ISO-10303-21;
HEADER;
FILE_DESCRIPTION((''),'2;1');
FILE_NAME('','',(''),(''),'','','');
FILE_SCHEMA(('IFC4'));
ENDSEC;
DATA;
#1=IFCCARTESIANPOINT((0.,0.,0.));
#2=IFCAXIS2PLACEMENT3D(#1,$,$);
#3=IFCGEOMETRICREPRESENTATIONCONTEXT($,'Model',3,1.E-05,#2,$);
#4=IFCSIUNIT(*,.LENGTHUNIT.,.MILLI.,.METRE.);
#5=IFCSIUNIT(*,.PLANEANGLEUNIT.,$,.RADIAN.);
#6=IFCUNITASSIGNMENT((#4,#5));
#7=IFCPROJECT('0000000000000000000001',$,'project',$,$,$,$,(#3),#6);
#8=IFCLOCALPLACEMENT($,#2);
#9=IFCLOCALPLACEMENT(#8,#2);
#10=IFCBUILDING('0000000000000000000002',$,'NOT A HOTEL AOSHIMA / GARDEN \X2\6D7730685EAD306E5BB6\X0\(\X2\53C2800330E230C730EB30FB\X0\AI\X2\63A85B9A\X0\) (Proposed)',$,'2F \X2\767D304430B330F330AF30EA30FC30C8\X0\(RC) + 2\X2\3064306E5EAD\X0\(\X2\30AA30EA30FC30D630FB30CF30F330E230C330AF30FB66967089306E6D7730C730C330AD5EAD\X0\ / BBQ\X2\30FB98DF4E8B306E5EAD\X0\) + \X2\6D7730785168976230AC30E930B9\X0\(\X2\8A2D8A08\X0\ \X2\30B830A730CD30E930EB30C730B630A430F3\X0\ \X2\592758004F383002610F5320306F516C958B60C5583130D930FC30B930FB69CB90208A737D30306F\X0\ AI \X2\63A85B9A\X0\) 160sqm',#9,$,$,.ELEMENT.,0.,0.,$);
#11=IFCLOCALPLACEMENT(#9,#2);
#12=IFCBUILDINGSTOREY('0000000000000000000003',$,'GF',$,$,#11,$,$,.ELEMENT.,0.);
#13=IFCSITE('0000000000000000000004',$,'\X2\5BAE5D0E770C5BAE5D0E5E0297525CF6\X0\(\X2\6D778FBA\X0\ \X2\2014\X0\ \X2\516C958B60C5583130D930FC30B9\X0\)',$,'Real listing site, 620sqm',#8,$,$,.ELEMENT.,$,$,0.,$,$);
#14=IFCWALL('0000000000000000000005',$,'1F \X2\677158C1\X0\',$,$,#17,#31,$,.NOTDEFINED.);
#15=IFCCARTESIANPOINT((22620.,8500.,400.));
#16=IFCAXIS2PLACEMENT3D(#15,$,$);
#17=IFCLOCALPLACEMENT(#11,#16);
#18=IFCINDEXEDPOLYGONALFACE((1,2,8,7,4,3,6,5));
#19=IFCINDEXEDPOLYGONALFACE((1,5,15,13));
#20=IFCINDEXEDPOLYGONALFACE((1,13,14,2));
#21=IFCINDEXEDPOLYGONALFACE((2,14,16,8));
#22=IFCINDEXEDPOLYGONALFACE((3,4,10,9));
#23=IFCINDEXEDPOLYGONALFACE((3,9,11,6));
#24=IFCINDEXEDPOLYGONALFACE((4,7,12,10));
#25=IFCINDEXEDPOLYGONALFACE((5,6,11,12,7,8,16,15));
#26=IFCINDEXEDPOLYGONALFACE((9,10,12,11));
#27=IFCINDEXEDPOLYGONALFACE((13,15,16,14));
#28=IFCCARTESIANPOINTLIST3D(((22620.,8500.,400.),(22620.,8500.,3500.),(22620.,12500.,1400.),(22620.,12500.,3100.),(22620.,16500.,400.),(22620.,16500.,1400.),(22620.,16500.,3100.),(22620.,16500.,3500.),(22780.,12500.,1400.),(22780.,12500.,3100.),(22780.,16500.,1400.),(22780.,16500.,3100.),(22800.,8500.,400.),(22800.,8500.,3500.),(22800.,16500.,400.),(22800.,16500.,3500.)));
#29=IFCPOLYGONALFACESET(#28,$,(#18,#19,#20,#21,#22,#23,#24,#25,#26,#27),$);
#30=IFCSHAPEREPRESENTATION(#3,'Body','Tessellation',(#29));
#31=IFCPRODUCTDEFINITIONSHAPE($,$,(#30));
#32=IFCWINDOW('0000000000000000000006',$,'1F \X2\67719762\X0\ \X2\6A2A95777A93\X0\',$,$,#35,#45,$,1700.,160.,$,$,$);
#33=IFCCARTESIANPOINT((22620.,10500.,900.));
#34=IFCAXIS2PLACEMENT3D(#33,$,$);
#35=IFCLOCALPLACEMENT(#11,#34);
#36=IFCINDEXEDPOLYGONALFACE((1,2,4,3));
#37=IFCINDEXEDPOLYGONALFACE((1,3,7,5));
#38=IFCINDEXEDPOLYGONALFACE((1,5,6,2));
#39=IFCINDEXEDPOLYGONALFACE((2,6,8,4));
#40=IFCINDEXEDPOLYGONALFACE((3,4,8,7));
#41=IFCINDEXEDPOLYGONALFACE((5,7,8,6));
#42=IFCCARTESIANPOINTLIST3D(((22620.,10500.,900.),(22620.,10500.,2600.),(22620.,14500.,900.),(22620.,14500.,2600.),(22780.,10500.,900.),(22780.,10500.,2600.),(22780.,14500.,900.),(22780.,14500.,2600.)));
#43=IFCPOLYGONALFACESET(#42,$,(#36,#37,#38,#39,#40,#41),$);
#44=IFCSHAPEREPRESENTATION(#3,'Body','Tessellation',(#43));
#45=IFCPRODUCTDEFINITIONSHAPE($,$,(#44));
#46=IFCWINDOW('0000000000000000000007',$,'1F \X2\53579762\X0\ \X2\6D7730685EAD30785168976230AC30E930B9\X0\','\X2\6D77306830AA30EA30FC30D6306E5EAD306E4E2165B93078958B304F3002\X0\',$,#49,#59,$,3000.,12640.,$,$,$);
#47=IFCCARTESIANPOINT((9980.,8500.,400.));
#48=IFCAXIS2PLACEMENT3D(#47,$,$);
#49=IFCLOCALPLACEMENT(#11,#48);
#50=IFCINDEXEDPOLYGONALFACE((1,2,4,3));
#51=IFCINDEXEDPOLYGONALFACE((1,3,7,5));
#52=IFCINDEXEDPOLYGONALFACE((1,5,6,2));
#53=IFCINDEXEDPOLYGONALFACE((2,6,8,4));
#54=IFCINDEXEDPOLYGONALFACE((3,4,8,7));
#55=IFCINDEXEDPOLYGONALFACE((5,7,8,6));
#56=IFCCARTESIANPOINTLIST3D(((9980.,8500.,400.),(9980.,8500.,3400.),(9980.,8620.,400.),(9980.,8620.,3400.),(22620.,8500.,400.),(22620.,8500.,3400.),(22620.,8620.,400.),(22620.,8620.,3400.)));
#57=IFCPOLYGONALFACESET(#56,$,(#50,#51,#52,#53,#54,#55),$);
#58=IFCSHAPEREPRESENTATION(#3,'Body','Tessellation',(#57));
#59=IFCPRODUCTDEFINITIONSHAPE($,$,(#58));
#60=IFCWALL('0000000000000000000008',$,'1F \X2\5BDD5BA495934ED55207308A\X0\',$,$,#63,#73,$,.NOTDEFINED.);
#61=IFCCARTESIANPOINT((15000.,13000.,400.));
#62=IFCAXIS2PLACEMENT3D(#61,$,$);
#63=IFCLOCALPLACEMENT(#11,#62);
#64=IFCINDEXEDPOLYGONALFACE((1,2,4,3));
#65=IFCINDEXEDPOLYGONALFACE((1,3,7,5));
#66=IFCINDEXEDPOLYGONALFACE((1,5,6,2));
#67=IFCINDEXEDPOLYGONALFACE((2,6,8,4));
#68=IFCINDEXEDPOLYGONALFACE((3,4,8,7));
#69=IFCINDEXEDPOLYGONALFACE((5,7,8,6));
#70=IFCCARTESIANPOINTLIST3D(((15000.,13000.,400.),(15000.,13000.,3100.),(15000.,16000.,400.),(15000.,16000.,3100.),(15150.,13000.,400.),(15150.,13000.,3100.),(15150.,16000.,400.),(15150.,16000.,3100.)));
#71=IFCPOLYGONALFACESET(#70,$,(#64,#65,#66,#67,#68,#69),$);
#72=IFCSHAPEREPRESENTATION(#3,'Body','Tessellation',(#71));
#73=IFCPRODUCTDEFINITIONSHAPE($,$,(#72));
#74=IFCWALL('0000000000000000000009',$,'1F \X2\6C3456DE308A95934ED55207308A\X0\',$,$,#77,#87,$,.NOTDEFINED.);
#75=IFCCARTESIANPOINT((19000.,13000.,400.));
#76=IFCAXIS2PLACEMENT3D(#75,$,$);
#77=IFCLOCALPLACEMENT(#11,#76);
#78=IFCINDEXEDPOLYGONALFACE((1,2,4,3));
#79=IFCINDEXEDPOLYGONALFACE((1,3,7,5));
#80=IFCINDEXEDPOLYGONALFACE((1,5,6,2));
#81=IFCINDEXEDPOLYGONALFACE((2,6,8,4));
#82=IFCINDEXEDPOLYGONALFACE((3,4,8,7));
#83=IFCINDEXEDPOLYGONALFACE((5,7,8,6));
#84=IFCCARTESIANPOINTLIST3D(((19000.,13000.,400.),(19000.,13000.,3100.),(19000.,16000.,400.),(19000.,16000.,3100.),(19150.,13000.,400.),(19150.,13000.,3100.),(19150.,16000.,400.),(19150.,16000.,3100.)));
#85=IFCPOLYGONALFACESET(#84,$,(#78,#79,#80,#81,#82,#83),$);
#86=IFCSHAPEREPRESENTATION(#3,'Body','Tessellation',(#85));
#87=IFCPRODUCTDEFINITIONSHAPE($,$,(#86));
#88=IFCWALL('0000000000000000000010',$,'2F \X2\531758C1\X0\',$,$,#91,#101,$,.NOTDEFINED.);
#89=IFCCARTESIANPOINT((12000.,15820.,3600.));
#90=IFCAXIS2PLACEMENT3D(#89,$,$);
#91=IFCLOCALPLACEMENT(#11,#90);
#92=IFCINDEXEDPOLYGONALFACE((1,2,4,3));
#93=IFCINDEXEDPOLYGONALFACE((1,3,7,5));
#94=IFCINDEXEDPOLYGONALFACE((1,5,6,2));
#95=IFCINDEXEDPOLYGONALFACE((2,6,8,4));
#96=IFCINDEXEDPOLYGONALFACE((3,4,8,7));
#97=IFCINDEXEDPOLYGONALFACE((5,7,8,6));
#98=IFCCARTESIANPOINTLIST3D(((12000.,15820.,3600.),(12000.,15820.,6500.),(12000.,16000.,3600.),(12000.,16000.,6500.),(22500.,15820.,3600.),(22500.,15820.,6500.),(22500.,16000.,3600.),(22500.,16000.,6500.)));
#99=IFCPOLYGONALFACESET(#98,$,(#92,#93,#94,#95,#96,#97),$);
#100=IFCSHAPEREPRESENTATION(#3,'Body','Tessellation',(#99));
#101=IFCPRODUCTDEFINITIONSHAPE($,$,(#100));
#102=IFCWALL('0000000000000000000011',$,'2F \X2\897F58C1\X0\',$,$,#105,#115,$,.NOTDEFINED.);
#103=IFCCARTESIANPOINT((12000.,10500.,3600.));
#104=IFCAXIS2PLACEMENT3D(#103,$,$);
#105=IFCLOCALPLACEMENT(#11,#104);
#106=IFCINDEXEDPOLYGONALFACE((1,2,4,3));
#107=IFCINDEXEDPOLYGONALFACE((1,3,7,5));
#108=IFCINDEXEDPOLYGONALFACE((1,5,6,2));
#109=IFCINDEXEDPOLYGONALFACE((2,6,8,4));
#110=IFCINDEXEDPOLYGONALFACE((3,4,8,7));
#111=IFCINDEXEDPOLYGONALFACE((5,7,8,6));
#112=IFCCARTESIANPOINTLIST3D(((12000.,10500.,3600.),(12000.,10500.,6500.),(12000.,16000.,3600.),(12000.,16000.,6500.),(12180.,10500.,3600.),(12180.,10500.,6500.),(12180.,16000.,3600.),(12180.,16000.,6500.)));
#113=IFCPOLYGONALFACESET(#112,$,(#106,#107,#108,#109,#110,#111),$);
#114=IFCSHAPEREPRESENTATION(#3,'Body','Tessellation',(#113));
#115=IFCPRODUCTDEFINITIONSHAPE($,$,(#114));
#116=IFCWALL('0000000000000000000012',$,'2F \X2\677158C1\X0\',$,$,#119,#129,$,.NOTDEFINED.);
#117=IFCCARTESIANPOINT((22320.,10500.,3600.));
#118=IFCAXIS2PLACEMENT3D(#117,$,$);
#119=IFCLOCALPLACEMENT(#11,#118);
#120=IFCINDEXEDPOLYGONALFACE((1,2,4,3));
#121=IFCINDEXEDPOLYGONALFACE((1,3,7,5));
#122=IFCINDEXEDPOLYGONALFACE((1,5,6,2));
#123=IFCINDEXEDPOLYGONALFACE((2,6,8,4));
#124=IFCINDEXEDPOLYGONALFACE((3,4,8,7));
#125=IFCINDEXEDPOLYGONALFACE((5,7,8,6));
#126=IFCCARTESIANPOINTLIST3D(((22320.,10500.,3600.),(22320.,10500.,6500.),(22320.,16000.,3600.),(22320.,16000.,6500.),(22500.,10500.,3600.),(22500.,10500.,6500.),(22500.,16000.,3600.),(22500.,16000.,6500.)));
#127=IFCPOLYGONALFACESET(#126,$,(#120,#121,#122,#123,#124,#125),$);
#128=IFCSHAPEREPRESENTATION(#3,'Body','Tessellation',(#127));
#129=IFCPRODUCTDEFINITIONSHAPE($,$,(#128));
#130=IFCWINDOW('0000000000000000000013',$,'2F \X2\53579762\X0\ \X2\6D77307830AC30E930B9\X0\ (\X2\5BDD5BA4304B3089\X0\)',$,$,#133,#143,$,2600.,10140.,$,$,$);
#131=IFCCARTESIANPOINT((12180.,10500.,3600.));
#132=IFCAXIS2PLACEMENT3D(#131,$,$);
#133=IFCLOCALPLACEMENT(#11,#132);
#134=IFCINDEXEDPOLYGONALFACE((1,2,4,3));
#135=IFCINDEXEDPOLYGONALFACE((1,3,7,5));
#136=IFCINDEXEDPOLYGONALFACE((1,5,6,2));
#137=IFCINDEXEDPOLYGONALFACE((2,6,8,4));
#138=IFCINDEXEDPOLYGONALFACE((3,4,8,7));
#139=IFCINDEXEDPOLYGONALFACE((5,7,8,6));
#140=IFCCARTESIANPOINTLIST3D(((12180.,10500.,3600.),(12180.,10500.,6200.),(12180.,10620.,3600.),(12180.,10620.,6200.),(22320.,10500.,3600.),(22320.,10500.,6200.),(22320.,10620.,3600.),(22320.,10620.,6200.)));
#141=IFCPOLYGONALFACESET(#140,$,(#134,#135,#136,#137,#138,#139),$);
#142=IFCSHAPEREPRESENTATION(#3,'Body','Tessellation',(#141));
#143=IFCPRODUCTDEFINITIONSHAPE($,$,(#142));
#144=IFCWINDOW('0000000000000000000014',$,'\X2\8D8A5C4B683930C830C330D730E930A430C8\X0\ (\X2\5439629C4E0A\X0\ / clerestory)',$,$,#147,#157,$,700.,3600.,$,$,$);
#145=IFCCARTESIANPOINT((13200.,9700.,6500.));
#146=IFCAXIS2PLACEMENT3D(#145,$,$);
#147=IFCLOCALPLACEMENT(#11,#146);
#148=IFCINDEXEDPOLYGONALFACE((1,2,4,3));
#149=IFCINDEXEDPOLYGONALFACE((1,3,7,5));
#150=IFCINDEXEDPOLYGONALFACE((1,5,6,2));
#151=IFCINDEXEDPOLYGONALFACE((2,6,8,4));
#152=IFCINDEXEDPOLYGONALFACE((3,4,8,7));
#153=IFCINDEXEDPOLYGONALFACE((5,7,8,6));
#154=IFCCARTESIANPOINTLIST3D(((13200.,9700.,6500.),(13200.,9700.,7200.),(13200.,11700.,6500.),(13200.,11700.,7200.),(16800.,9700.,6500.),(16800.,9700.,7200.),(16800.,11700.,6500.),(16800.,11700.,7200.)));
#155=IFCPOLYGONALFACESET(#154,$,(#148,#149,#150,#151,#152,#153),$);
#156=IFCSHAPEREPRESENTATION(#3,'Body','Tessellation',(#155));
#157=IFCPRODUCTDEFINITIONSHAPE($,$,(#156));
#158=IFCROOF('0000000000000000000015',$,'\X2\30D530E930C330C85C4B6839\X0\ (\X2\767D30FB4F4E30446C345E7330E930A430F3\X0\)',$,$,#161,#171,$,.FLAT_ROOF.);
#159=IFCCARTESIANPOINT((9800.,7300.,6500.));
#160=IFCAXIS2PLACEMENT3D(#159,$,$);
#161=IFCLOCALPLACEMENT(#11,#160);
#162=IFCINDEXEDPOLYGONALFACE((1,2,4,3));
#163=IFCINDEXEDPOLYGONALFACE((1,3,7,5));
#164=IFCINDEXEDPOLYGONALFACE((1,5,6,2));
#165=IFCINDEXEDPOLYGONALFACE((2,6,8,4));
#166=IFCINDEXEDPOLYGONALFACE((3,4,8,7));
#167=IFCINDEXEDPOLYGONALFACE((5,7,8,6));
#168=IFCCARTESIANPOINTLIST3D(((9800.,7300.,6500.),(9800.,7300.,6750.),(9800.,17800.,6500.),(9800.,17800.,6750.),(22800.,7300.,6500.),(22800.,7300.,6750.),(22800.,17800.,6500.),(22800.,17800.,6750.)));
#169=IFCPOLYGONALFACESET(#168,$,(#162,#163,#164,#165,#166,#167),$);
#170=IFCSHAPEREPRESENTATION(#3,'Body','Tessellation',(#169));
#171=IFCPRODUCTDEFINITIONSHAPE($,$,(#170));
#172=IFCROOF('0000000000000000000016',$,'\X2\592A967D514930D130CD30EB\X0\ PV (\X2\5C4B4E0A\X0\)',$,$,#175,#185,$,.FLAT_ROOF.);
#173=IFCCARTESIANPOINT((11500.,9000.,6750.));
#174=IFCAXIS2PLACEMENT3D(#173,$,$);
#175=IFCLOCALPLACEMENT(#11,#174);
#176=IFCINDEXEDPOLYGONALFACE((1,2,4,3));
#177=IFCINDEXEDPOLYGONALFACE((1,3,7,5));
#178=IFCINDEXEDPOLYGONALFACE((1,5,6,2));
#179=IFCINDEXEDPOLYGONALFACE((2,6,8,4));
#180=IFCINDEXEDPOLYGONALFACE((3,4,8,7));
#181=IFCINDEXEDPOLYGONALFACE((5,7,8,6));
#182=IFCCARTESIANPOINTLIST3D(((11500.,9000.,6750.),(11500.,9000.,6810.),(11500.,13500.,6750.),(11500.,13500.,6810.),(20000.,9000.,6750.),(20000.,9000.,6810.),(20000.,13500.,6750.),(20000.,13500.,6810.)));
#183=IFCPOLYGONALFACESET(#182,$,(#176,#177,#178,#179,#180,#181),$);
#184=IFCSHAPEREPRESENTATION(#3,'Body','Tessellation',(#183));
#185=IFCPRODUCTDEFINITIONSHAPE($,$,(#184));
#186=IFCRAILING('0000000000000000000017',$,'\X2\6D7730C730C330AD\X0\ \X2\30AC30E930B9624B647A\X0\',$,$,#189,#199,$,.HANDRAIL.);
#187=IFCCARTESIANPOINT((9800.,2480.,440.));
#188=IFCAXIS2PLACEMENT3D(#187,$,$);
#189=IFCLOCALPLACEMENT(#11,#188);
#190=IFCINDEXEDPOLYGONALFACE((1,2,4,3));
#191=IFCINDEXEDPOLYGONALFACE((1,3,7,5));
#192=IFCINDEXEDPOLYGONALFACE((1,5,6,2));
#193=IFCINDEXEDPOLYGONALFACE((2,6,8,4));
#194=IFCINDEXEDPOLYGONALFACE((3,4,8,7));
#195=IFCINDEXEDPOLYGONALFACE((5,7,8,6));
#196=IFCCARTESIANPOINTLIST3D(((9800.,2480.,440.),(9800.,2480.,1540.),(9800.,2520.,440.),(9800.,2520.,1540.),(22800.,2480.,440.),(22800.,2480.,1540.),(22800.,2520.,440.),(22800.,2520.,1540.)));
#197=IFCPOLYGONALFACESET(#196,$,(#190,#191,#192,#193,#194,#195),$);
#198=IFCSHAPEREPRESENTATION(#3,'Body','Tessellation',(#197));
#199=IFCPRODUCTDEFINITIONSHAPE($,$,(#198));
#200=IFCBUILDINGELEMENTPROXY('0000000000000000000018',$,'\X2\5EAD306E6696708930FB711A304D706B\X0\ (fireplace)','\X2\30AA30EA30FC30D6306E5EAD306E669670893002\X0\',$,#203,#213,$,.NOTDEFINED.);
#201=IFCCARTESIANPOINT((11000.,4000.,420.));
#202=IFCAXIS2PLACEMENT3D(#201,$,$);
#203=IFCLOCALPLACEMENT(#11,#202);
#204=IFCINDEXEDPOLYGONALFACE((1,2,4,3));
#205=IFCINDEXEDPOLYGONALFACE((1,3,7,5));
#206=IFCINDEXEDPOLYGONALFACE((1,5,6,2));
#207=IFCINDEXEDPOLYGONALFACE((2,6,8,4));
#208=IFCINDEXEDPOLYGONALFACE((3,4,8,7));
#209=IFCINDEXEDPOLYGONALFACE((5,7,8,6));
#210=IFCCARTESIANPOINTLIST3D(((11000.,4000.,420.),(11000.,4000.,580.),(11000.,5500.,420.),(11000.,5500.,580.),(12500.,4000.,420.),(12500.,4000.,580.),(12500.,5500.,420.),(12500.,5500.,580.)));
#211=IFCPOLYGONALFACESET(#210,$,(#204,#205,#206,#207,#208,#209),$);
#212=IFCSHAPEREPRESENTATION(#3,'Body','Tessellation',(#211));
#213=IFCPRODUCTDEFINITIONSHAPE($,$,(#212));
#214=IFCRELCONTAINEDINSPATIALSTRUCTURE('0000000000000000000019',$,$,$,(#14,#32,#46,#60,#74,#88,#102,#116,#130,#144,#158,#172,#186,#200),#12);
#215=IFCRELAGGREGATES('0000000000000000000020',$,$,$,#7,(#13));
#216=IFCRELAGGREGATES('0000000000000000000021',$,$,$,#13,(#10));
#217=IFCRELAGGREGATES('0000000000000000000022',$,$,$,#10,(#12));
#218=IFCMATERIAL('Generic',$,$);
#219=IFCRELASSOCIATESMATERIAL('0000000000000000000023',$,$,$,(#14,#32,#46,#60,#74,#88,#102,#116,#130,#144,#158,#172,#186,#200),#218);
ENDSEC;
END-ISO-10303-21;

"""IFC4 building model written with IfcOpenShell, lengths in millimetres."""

from ifc_helpers import new_model, si_unit, frame, frame_2d, origin, place, context, project, spatial, rectangle, extrude, material, element, fill, save


model = new_model("IFC4")

# Units and contexts
model_context = context("Model", 3, precision=1e-05, world=origin())
ifc_project = project(units=[si_unit("LENGTHUNIT", "METRE", prefix="MILLI"), si_unit("PLANEANGLEUNIT", "RADIAN")], contexts=[model_context])

# Site, building, storey
site_placement = place(None, origin())
site = spatial("IfcSite", under=ifc_project, at=site_placement, Name="宮崎県宮崎市青島(海辺 — 公開情報ベース)", ObjectType="Real listing site, 620sqm", CompositionType="ELEMENT", RefElevation=0.0)
building_placement = place(site_placement, origin())
building = spatial("IfcBuilding", under=site, at=building_placement, Name="NOT A HOTEL AOSHIMA / GARDEN 海と庭の家(参考モデル・AI推定) (Proposed)", ObjectType="2F 白いコンクリート(RC) + 2つの庭(オリーブ・ハンモック・暖炉の海デッキ庭 / BBQ・食事の庭) + 海へ全面ガラス(設計 ジェネラルデザイン 大堀伸。意匠は公開情報ベース・構造詳細は AI 推定) 160sqm", CompositionType="ELEMENT", ElevationOfRefHeight=0.0, ElevationOfTerrain=0.0)
storey_placement = place(building_placement, origin())
storey = spatial("IfcBuildingStorey", under=building, at=storey_placement, Name="GF", CompositionType="ELEMENT", Elevation=0.0)

# Shared definitions
ifc_material_1 = material(Name="Generic")

# Wall, opening, window
wall_1_placement = place(storey_placement, frame((22620.0, 8500.0, 400.0)))
wall_1 = element("IfcWall", 1, at=wall_1_placement, inside=storey, material=ifc_material_1, Name="1F 東壁", PredefinedType="NOTDEFINED", context=model_context, shape_type="SweptSolid", body=[
    extrude(rectangle(XDim=180.0, YDim=8000.0, at=frame_2d((90.0, 4000.0))), frame((22620.0, 8500.0, 400.0)), (0.0, 0.0, 1.0), 3100.0),
])
opening_1_placement = place(storey_placement, frame((22620.0, 10500.0, 900.0)))
opening_1 = element("IfcOpeningElement", 2, at=opening_1_placement, cuts=wall_1, PredefinedType="NOTDEFINED", context=model_context, shape_type="SweptSolid", body=[
    extrude(rectangle(XDim=160.0, YDim=4000.0, at=frame_2d((80.0, 2000.0))), frame((22620.0, 10500.0, 900.0)), (0.0, 0.0, 1.0), 1700.0),
])
window_1_placement = place(storey_placement, frame((22620.0, 10500.0, 900.0)))
window_1 = element("IfcWindow", 3, at=window_1_placement, inside=storey, material=ifc_material_1, Name="1F 東面 横長窓", OverallHeight=1700.0, OverallWidth=160.0, context=model_context, shape_type="SweptSolid", body=[
    extrude(rectangle(XDim=160.0, YDim=4000.0, at=frame_2d((80.0, 2000.0))), frame((22620.0, 10500.0, 900.0)), (0.0, 0.0, 1.0), 1700.0),
])
fill(opening_1, window_1)

# Window
window_2_placement = place(storey_placement, frame((9980.0, 8500.0, 400.0)))
element("IfcWindow", 4, at=window_2_placement, inside=storey, material=ifc_material_1, Name="1F 南面 海と庭へ全面ガラス", Description="海とオリーブの庭の両方へ開く。", OverallHeight=3000.0, OverallWidth=12640.0, context=model_context, shape_type="SweptSolid", body=[
    extrude(rectangle(XDim=12640.0, YDim=120.0, at=frame_2d((6320.0, 60.0))), frame((9980.0, 8500.0, 400.0)), (0.0, 0.0, 1.0), 3000.0),
])

# Walls
wall_2_placement = place(storey_placement, frame((15000.0, 13000.0, 400.0)))
element("IfcWall", 5, at=wall_2_placement, inside=storey, material=ifc_material_1, Name="1F 寝室間仕切り", PredefinedType="NOTDEFINED", context=model_context, shape_type="SweptSolid", body=[
    extrude(rectangle(XDim=150.0, YDim=3000.0, at=frame_2d((75.0, 1500.0))), frame((15000.0, 13000.0, 400.0)), (0.0, 0.0, 1.0), 2700.0),
])
wall_3_placement = place(storey_placement, frame((19000.0, 13000.0, 400.0)))
element("IfcWall", 6, at=wall_3_placement, inside=storey, material=ifc_material_1, Name="1F 水回り間仕切り", PredefinedType="NOTDEFINED", context=model_context, shape_type="SweptSolid", body=[
    extrude(rectangle(XDim=150.0, YDim=3000.0, at=frame_2d((75.0, 1500.0))), frame((19000.0, 13000.0, 400.0)), (0.0, 0.0, 1.0), 2700.0),
])
wall_4_placement = place(storey_placement, frame((12000.0, 15820.0, 3600.0)))
element("IfcWall", 7, at=wall_4_placement, inside=storey, material=ifc_material_1, Name="2F 北壁", PredefinedType="NOTDEFINED", context=model_context, shape_type="SweptSolid", body=[
    extrude(rectangle(XDim=10500.0, YDim=180.0, at=frame_2d((5250.0, 90.0))), frame((12000.0, 15820.0, 3600.0)), (0.0, 0.0, 1.0), 2900.0),
])
wall_5_placement = place(storey_placement, frame((12000.0, 10500.0, 3600.0)))
element("IfcWall", 8, at=wall_5_placement, inside=storey, material=ifc_material_1, Name="2F 西壁", PredefinedType="NOTDEFINED", context=model_context, shape_type="SweptSolid", body=[
    extrude(rectangle(XDim=180.0, YDim=5500.0, at=frame_2d((90.0, 2750.0))), frame((12000.0, 10500.0, 3600.0)), (0.0, 0.0, 1.0), 2900.0),
])
wall_6_placement = place(storey_placement, frame((22320.0, 10500.0, 3600.0)))
element("IfcWall", 9, at=wall_6_placement, inside=storey, material=ifc_material_1, Name="2F 東壁", PredefinedType="NOTDEFINED", context=model_context, shape_type="SweptSolid", body=[
    extrude(rectangle(XDim=180.0, YDim=5500.0, at=frame_2d((90.0, 2750.0))), frame((22320.0, 10500.0, 3600.0)), (0.0, 0.0, 1.0), 2900.0),
])

# Windows
window_3_placement = place(storey_placement, frame((12180.0, 10500.0, 3600.0)))
element("IfcWindow", 10, at=window_3_placement, inside=storey, material=ifc_material_1, Name="2F 南面 海へガラス (寝室から)", OverallHeight=2600.0, OverallWidth=10140.0, context=model_context, shape_type="SweptSolid", body=[
    extrude(rectangle(XDim=10140.0, YDim=120.0, at=frame_2d((5070.0, 60.0))), frame((12180.0, 10500.0, 3600.0)), (0.0, 0.0, 1.0), 2600.0),
])
window_4_placement = place(storey_placement, frame((13200.0, 9700.0, 6500.0)))
element("IfcWindow", 11, at=window_4_placement, inside=storey, material=ifc_material_1, Name="越屋根トップライト (吹抜上 / clerestory)", OverallHeight=700.0, OverallWidth=3600.0, context=model_context, shape_type="SweptSolid", body=[
    extrude(rectangle(XDim=3600.0, YDim=2000.0, at=frame_2d((1800.0, 1000.0))), frame((13200.0, 9700.0, 6500.0)), (0.0, 0.0, 1.0), 700.0),
])

# Roofs
roof_1_placement = place(storey_placement, frame((9800.0, 7300.0, 6500.0)))
element("IfcRoof", 12, at=roof_1_placement, inside=storey, material=ifc_material_1, Name="フラット屋根 (白・低い水平ライン)", PredefinedType="FLAT_ROOF", context=model_context, shape_type="SweptSolid", body=[
    extrude(rectangle(XDim=13000.0, YDim=10500.0, at=frame_2d((6500.0, 5250.0))), frame((9800.0, 7300.0, 6500.0)), (0.0, 0.0, 1.0), 250.0),
])
roof_2_placement = place(storey_placement, frame((11500.0, 9000.0, 6750.0)))
element("IfcRoof", 13, at=roof_2_placement, inside=storey, material=ifc_material_1, Name="太陽光パネル PV (屋上)", PredefinedType="FLAT_ROOF", context=model_context, shape_type="SweptSolid", body=[
    extrude(rectangle(XDim=8500.0, YDim=4500.0, at=frame_2d((4250.0, 2250.0))), frame((11500.0, 9000.0, 6750.0)), (0.0, 0.0, 1.0), 60.0),
])

# Railing
railing_placement = place(storey_placement, frame((9800.0, 2480.0, 440.0)))
element("IfcRailing", 14, at=railing_placement, inside=storey, material=ifc_material_1, Name="海デッキ ガラス手摺", PredefinedType="HANDRAIL", context=model_context, shape_type="SweptSolid", body=[
    extrude(rectangle(XDim=13000.0, YDim=40.0, at=frame_2d((6500.0, 20.0))), frame((9800.0, 2480.0, 440.0)), (0.0, 0.0, 1.0), 1100.0),
])

# Building element proxy
proxy_1_placement = place(storey_placement, frame((11000.0, 4000.0, 420.0)))
element("IfcBuildingElementProxy", 15, at=proxy_1_placement, inside=storey, material=ifc_material_1, Name="庭の暖炉・焚き火 (fireplace)", Description="オリーブの庭の暖炉。", PredefinedType="NOTDEFINED", context=model_context, shape_type="SweptSolid", body=[
    extrude(rectangle(XDim=1500.0, YDim=1500.0, at=frame_2d((750.0, 750.0))), frame((11000.0, 4000.0, 420.0)), (0.0, 0.0, 1.0), 160.0),
])

save(model, "model.ifc")
